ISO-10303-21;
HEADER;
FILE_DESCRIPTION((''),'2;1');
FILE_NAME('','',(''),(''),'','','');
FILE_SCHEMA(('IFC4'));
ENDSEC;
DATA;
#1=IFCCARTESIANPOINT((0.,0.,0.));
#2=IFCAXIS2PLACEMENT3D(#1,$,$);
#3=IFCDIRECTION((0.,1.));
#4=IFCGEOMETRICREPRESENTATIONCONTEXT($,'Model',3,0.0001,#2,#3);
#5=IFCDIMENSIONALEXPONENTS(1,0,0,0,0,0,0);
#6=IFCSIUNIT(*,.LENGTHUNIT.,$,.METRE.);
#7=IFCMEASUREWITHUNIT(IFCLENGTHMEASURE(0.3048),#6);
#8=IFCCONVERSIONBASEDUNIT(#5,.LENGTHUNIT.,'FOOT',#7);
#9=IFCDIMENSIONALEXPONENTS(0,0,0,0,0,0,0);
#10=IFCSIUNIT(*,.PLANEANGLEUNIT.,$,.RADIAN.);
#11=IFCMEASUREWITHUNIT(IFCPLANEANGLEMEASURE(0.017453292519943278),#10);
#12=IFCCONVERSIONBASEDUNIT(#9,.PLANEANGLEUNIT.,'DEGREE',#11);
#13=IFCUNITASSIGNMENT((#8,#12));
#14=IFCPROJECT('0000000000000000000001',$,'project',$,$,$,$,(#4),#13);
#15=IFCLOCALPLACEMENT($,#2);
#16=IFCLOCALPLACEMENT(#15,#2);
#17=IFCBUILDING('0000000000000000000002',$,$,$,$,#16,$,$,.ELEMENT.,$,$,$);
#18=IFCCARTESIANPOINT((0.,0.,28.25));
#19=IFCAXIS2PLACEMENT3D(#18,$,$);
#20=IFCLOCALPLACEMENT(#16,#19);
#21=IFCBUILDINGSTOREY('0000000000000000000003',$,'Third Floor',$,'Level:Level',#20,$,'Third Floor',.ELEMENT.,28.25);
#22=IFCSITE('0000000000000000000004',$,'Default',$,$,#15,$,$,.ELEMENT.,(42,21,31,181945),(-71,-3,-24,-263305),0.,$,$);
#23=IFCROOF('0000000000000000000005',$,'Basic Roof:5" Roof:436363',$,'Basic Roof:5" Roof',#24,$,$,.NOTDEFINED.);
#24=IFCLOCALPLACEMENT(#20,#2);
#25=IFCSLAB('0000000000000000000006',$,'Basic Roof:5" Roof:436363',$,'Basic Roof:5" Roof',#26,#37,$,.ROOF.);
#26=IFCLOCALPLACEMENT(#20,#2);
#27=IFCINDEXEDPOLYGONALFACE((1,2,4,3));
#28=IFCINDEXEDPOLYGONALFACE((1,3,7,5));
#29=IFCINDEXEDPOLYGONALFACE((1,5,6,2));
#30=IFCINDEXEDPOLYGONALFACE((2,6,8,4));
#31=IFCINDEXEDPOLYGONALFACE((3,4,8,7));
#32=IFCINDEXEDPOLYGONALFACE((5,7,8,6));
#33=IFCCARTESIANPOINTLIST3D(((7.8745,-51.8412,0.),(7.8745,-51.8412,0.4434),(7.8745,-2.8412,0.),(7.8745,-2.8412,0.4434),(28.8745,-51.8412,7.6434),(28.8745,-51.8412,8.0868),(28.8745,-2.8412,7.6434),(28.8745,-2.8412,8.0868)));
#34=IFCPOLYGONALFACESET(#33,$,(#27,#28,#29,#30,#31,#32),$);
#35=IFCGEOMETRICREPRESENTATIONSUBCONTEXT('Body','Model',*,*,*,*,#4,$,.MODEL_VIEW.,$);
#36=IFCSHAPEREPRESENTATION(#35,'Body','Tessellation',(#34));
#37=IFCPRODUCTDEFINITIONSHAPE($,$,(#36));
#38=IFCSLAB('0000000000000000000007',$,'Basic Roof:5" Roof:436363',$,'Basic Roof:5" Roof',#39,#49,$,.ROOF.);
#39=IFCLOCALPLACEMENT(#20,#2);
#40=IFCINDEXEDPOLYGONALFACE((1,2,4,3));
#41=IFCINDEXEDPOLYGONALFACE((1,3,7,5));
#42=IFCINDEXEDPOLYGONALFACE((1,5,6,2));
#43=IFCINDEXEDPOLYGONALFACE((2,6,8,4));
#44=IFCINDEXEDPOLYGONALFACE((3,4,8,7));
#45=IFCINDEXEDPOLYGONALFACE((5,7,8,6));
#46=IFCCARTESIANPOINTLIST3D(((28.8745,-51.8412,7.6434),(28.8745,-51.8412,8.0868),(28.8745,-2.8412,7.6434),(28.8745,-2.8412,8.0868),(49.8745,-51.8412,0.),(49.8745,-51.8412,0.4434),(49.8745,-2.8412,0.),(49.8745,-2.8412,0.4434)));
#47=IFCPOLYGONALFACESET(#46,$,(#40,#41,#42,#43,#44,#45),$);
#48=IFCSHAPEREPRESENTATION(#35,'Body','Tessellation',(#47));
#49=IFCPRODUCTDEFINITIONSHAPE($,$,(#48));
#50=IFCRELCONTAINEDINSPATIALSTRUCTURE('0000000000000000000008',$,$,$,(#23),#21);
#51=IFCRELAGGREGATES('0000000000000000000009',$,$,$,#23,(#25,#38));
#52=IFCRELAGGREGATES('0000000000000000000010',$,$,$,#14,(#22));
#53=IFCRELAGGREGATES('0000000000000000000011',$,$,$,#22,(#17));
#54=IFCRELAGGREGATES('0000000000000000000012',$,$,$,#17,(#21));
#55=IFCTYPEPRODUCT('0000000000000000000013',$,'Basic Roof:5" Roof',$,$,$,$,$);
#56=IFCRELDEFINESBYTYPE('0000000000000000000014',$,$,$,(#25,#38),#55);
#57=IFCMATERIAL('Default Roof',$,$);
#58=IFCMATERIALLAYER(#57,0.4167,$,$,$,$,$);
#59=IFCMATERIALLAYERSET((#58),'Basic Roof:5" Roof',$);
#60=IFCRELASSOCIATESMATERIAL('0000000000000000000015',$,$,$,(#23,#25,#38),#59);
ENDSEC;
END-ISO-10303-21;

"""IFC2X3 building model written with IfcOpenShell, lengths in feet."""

from ifc_helpers import new_model, entity, si_unit, converted_unit, direction, frame, frame_2d, origin, origin_2d_with_axis, place, context, subcontext, project, spatial, rectangle, extrude, material, layer, layer_set, type_object, element, aggregate, save


model = new_model("IFC2X3")

# Units and contexts
model_context = context("Model", 3, precision=0.0001, world=origin(), true_north=direction((0.0, 1.0)))
body_context = subcontext(model_context, "Body", "Model", "MODEL_VIEW")
ifc_project = project(units=[converted_unit("LENGTHUNIT", "FOOT", entity("IfcLengthMeasure", 0.3048), si_unit("LENGTHUNIT", "METRE"), dimensions=[1, 0, 0, 0, 0, 0, 0]), converted_unit("PLANEANGLEUNIT", "DEGREE", entity("IfcPlaneAngleMeasure", 0.017453292519943278), si_unit("PLANEANGLEUNIT", "RADIAN"), dimensions=[0, 0, 0, 0, 0, 0, 0])], contexts=[model_context])

# Site, building, storey
site_placement = place(None, origin())
site = spatial("IfcSite", under=ifc_project, at=site_placement, Name="Default", CompositionType="ELEMENT", RefLatitude=(42, 21, 31, 181945), RefLongitude=(-71, -3, -24, -263305), RefElevation=0.0)
building_placement = place(site_placement, origin())
building = spatial("IfcBuilding", under=site, at=building_placement, CompositionType="ELEMENT")
storey_placement = place(building_placement, frame((0.0, 0.0, 28.25)))
storey = spatial("IfcBuildingStorey", under=building, at=storey_placement, Name="Third Floor", ObjectType="Level:Level", LongName="Third Floor", CompositionType="ELEMENT", Elevation=28.25)

# Roof, slabs
ifc_material = material(Name="Default Roof")
ifc_layer = layer(ifc_material, 0.4167)
ifc_layer_set = layer_set([ifc_layer], Name="Basic Roof:5\" Roof")
roof_placement = place(storey_placement, frame((7.8745, -51.8412, 0.0)))
roof = element("IfcRoof", 1, at=roof_placement, inside=storey, material=ifc_layer_set, Name="Basic Roof:5\" Roof:436363", ObjectType="Basic Roof:5\" Roof", ShapeType="NOTDEFINED")
type_product = type_object("IfcTypeProduct", Name="Basic Roof:5\" Roof")
slab_1_placement = place(roof_placement, origin())
slab_1 = element("IfcSlab", 2, at=slab_1_placement, type_object=type_product, material=ifc_layer_set, Name="Basic Roof:5\" Roof:436363", ObjectType="Basic Roof:5\" Roof", PredefinedType="ROOF", context=body_context, shape_type="SweptSolid", body=[
    extrude(rectangle(XDim=49.0, YDim=22.3477, at=frame_2d((0.0, 0.0), x_axis=(0.0, 1.0))), frame((10.5, 24.5, 3.8217), z_axis=(-0.34202, 0.0, 0.939693), x_axis=(0.939693, 0.0, 0.34202)), (0.34202, 0.0, 0.939693), 0.4434),
])
slab_2_placement = place(roof_placement, origin())
slab_2 = element("IfcSlab", 3, at=slab_2_placement, type_object=type_product, material=ifc_layer_set, Name="Basic Roof:5\" Roof:436363", ObjectType="Basic Roof:5\" Roof", PredefinedType="ROOF", context=body_context, shape_type="SweptSolid", body=[
    extrude(rectangle(XDim=22.3477, YDim=49.0, at=origin_2d_with_axis()), frame((31.5, 24.5, 3.8217), z_axis=(0.34202, 0.0, 0.939693), x_axis=(0.939693, 0.0, -0.34202)), (-0.34202, 0.0, 0.939693), 0.4434),
])
aggregate(roof, [slab_1, slab_2])

save(model, "model.ifc")
